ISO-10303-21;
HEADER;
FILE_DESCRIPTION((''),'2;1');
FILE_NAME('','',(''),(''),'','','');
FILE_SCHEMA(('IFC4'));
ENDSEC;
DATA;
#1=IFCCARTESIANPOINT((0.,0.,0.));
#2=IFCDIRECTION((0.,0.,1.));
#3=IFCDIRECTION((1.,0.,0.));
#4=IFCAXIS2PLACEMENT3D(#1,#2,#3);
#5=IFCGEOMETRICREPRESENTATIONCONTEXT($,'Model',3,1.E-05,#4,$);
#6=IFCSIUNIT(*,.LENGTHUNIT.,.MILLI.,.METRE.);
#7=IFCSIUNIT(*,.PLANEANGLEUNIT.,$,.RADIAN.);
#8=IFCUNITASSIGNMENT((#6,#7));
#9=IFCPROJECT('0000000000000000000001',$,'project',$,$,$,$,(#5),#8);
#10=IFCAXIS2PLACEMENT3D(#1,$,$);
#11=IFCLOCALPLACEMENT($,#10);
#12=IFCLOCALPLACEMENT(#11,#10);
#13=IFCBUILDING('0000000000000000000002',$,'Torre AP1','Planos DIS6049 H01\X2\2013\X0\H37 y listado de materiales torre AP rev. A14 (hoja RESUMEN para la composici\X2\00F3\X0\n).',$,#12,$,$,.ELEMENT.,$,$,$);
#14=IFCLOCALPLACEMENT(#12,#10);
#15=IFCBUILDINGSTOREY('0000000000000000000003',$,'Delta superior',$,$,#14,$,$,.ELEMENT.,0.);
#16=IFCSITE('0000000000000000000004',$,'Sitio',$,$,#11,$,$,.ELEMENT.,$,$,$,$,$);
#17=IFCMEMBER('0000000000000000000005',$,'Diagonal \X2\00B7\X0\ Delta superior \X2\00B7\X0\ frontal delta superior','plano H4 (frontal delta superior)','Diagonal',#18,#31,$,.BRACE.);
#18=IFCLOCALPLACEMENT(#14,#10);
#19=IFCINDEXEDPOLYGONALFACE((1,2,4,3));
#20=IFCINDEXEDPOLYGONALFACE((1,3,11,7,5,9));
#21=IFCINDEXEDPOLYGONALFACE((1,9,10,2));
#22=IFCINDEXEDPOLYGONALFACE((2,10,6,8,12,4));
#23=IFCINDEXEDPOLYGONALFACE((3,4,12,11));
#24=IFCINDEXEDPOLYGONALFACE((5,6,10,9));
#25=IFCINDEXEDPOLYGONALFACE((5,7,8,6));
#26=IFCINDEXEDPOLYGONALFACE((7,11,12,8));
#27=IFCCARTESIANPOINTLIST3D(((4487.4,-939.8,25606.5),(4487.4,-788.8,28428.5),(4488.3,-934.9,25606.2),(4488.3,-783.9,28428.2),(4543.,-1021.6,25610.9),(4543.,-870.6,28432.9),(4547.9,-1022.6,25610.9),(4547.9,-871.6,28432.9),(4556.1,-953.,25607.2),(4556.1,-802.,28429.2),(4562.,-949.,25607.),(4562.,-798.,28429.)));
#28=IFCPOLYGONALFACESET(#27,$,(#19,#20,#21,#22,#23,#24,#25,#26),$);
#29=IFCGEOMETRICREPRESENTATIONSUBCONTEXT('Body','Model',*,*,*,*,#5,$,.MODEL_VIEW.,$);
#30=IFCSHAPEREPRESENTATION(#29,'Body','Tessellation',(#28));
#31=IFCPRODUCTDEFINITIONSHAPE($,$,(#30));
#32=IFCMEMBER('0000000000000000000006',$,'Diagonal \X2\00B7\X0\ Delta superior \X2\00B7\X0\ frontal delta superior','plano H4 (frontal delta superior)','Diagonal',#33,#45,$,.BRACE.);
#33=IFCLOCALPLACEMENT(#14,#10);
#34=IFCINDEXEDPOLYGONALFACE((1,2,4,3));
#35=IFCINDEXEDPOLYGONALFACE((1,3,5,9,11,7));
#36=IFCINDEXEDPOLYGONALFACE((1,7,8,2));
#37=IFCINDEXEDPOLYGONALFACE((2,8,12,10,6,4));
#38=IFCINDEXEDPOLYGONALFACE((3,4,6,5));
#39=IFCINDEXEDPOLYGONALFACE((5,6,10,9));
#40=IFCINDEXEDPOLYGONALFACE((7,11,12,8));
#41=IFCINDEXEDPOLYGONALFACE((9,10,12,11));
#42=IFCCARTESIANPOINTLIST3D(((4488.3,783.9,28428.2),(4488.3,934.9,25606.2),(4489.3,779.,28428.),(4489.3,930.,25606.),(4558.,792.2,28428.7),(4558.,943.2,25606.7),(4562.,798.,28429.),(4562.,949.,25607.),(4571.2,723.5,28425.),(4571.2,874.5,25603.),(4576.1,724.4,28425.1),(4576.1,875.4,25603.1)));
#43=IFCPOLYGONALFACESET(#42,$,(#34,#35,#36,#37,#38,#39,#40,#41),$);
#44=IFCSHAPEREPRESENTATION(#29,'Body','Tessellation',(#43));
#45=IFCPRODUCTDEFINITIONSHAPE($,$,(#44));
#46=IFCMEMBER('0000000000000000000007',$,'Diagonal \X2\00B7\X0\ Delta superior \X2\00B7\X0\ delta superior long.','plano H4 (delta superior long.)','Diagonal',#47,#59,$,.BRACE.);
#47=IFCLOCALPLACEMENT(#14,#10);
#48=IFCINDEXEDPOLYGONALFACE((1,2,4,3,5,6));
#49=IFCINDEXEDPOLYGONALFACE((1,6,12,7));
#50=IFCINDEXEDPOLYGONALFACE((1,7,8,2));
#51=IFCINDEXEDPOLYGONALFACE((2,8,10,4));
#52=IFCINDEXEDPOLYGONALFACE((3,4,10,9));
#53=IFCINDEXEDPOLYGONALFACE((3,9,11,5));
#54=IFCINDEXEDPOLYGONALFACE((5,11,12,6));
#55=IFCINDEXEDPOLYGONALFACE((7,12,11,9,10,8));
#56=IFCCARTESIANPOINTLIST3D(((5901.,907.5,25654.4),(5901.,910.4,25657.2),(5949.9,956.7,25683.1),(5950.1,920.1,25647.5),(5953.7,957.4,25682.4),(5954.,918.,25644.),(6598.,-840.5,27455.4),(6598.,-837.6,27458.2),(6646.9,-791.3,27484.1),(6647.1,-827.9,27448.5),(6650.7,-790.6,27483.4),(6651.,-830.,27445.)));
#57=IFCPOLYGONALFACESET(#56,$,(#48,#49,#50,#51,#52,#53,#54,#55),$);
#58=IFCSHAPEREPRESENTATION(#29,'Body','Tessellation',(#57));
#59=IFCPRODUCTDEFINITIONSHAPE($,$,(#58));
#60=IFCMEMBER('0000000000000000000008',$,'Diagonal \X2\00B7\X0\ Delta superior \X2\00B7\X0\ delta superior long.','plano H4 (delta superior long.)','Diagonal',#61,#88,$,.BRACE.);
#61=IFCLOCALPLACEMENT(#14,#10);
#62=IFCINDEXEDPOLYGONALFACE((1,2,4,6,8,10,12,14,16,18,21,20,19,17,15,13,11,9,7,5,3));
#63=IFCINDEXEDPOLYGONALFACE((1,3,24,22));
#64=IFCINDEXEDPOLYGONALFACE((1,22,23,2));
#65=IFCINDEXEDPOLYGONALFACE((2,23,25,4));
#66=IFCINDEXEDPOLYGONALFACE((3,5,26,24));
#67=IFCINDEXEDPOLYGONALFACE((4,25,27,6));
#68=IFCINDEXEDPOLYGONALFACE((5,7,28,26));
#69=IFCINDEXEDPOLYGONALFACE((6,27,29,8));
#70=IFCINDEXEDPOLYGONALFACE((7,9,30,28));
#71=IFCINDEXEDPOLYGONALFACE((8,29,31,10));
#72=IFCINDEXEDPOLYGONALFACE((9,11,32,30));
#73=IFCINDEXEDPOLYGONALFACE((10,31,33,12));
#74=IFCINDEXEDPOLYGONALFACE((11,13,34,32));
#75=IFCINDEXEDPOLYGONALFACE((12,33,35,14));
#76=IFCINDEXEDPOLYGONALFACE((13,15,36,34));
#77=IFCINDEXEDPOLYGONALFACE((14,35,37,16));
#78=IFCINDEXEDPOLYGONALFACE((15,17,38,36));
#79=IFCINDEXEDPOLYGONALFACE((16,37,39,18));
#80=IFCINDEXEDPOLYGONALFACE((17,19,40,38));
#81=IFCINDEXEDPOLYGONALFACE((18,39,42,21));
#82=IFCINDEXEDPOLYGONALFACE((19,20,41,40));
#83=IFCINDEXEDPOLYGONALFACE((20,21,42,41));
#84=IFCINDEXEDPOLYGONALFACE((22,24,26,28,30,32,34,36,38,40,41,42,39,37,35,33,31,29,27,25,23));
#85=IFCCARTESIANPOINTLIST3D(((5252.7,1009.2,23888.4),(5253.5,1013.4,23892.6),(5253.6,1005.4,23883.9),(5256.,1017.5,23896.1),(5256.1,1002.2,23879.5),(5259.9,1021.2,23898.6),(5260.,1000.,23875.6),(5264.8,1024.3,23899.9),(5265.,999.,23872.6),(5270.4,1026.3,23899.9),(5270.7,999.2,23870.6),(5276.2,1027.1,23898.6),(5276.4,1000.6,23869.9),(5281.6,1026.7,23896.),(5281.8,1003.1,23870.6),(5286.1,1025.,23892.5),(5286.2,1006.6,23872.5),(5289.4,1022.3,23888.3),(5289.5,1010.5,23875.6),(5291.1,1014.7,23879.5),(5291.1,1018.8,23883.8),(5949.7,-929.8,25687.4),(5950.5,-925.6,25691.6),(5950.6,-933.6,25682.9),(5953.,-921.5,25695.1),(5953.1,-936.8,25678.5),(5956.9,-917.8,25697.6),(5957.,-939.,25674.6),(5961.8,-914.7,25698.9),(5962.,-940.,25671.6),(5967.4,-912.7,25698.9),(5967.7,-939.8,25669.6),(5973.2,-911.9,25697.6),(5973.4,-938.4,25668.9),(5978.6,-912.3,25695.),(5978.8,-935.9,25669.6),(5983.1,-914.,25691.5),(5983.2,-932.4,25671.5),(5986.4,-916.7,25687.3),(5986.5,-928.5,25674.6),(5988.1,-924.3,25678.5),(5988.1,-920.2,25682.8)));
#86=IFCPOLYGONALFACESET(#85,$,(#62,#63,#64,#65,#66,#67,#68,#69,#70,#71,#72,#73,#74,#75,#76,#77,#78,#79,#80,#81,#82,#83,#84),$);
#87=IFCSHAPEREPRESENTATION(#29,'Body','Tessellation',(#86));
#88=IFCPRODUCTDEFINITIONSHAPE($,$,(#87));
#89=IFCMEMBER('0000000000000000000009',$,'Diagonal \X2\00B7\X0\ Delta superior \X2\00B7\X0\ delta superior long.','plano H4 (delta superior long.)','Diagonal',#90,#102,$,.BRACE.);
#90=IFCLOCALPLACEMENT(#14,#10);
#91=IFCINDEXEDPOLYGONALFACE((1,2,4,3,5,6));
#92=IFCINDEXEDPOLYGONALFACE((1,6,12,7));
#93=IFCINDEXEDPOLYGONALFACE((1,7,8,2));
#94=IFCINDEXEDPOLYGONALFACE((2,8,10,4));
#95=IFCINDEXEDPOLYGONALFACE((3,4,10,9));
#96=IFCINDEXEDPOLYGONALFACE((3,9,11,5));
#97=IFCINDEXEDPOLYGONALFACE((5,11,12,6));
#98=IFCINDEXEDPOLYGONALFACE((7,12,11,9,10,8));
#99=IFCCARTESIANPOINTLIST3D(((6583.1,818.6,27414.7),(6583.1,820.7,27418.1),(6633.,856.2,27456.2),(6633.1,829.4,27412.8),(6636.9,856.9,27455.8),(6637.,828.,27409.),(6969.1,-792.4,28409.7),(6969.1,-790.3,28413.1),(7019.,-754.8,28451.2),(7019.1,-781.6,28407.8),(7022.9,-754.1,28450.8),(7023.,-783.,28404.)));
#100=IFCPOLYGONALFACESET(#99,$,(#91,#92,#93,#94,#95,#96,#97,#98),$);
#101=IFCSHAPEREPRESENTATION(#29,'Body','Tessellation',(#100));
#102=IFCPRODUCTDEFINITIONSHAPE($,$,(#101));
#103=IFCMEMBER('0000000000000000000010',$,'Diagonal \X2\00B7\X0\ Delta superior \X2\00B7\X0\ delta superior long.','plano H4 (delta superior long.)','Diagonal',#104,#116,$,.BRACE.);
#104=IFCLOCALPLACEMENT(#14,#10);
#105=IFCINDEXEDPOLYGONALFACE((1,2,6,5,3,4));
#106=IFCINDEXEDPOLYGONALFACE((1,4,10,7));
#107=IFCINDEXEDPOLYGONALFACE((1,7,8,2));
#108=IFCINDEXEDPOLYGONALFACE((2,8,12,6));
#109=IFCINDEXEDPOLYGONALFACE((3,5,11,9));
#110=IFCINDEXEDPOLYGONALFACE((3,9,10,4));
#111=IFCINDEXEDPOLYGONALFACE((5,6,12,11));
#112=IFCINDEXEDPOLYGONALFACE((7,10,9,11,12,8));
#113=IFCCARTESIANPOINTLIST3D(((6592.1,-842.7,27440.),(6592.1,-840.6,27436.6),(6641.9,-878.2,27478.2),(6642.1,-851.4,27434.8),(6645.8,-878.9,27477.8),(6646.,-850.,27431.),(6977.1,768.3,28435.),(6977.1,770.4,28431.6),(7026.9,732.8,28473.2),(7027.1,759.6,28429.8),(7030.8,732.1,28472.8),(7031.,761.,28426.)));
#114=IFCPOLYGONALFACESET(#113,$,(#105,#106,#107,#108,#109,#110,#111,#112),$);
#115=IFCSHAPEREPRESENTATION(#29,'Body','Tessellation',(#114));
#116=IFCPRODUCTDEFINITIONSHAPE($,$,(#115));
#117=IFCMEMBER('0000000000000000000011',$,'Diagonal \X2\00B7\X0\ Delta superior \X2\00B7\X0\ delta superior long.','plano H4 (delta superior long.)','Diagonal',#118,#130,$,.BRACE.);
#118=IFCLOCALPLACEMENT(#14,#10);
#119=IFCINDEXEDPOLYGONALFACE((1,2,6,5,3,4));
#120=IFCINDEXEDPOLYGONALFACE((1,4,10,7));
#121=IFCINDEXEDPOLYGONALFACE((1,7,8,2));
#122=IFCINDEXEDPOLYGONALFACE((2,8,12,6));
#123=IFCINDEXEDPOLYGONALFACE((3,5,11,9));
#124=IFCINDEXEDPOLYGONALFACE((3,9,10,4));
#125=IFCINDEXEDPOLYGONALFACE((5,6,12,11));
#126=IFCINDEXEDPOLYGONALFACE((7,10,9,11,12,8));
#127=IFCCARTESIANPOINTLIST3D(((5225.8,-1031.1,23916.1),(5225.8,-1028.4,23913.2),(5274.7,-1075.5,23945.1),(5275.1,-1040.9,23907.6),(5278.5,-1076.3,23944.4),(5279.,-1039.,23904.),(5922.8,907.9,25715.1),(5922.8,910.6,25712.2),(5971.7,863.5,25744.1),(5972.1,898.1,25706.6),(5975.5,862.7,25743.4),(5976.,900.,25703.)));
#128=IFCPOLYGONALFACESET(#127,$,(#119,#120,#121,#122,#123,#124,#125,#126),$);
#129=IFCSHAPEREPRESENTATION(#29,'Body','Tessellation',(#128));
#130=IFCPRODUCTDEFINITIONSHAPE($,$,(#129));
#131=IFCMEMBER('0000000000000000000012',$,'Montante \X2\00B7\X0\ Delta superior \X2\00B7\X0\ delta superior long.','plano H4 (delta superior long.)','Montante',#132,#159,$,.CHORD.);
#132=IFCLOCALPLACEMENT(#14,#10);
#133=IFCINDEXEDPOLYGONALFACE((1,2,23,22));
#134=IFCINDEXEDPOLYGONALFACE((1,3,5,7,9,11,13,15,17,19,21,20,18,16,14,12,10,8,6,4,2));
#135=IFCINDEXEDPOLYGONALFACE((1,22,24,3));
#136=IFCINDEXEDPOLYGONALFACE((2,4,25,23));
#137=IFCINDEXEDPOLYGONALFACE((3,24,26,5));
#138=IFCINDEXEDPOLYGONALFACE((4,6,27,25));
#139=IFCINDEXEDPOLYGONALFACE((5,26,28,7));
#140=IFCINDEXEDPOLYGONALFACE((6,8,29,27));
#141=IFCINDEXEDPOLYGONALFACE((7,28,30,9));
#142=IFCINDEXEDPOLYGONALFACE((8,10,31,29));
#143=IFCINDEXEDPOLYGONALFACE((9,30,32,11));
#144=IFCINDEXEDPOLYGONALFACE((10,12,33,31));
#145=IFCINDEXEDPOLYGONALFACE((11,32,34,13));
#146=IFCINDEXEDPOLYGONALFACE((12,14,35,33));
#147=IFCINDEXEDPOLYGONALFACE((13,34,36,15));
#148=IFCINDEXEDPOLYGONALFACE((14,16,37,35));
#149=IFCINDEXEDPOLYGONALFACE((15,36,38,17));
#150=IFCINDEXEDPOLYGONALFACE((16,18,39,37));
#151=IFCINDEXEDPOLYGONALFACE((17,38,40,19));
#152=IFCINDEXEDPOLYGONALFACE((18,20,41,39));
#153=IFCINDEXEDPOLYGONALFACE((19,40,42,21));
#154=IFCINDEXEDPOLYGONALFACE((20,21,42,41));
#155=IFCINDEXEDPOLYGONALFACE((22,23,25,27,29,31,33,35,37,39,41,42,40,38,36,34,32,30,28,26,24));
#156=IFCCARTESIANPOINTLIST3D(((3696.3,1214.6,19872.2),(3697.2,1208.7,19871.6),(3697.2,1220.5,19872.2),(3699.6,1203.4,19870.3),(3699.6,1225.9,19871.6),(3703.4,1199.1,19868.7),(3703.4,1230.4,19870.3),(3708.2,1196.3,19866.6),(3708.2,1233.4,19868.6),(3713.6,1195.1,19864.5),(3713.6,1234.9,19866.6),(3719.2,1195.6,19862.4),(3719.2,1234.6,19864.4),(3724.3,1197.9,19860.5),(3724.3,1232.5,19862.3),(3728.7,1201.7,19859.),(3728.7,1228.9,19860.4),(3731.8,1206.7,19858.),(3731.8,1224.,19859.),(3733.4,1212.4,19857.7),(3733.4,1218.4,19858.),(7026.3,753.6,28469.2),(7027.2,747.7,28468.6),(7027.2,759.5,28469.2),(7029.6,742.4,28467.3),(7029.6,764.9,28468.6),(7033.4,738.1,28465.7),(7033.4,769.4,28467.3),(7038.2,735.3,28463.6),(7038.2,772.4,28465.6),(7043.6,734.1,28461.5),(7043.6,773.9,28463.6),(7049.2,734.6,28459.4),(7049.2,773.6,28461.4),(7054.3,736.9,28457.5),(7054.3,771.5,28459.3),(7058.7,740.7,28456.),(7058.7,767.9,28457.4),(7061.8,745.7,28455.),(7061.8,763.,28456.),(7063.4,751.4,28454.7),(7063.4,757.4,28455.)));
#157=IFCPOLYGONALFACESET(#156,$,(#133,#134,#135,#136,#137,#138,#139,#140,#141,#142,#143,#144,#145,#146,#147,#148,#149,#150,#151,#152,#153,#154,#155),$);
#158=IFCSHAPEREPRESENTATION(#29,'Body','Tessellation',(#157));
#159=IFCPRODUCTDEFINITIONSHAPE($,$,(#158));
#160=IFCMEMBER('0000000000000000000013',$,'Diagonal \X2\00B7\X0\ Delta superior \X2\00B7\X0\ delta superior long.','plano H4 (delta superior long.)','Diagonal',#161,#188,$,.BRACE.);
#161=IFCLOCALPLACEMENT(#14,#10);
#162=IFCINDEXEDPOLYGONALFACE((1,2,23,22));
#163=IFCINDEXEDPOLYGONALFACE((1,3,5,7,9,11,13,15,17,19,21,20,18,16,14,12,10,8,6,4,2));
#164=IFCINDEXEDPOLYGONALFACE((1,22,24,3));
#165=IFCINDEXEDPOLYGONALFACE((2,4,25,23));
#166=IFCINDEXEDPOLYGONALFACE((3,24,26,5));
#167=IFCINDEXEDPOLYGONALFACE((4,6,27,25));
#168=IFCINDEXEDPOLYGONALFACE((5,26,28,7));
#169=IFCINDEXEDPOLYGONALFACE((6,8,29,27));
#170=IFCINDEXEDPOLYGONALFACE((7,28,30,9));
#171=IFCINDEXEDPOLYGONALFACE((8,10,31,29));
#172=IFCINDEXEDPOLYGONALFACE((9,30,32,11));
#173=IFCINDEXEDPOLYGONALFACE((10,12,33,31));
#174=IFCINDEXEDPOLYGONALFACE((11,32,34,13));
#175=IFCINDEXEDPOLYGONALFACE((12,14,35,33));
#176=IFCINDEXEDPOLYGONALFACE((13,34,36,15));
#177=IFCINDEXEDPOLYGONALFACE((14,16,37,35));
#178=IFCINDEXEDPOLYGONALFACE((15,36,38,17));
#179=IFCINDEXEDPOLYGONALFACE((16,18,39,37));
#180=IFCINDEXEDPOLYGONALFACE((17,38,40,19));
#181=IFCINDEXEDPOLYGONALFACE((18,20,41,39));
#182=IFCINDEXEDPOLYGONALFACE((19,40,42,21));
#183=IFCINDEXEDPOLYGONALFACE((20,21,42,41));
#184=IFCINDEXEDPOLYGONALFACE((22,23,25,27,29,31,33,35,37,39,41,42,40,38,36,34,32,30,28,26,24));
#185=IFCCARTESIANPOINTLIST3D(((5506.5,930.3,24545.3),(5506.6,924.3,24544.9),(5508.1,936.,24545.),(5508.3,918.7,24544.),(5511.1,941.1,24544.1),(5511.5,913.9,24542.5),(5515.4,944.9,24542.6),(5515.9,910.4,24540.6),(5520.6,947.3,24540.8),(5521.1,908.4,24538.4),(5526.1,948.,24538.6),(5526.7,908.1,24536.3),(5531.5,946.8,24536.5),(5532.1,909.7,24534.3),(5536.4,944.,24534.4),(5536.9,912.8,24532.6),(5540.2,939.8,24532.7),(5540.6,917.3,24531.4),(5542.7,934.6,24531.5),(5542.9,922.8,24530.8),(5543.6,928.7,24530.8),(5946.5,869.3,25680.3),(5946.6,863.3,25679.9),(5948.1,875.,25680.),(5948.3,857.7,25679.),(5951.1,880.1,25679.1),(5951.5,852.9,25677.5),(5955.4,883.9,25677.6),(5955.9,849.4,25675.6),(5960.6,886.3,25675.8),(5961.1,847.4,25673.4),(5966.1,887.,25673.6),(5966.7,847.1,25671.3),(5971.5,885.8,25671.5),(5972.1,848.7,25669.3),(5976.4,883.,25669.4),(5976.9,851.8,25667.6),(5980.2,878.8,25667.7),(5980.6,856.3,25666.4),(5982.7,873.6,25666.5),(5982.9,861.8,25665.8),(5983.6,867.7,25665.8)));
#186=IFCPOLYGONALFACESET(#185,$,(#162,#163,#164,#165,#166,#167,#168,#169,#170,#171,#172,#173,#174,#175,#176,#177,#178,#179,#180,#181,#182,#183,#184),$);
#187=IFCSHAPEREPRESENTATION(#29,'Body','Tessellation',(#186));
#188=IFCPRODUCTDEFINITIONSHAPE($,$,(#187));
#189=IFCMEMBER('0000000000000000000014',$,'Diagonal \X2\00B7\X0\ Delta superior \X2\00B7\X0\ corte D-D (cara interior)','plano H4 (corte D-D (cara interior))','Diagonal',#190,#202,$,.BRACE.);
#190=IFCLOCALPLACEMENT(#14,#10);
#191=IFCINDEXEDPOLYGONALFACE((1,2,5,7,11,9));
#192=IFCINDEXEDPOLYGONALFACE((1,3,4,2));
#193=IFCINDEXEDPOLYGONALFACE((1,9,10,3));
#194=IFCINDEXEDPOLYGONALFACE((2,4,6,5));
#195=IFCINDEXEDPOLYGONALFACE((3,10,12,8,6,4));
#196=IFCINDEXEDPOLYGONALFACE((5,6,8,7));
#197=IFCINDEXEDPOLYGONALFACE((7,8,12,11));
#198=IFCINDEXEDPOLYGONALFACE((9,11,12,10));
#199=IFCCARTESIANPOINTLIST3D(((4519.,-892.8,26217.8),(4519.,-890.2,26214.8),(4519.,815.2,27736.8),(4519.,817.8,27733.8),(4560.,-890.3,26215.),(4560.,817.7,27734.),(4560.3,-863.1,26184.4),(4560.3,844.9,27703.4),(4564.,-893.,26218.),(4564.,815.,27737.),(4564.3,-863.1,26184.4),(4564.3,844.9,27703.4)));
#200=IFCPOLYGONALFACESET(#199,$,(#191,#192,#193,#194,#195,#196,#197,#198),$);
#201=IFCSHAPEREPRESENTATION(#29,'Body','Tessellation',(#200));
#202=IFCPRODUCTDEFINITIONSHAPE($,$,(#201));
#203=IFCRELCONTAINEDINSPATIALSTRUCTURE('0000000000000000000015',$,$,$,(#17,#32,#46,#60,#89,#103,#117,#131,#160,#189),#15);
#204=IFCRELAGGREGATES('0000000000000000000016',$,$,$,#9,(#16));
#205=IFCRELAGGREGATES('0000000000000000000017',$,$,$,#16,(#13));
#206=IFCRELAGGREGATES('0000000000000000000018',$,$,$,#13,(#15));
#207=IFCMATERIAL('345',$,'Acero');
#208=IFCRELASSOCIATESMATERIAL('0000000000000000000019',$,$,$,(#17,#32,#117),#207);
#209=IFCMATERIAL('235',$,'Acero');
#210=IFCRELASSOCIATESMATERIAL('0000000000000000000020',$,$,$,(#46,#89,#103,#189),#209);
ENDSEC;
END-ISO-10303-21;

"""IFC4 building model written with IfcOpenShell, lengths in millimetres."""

from ifc_helpers import new_model, si_unit, frame, frame_2d, origin, origin_with_axes, place, context, subcontext, project, spatial, circle, l_section, extrude, material, element, save


model = new_model("IFC4")

# Units and contexts
model_context = context("Model", 3, precision=1e-05, world=origin_with_axes())
body_context = subcontext(model_context, "Body", "Model", "MODEL_VIEW")
ifc_project = project(units=[si_unit("LENGTHUNIT", "METRE", prefix="MILLI"), si_unit("PLANEANGLEUNIT", "RADIAN")], contexts=[model_context])

# Site, building, storey
site_placement = place(None, origin())
site = spatial("IfcSite", under=ifc_project, at=site_placement, Name="Sitio", CompositionType="ELEMENT")
building_placement = place(site_placement, origin())
building = spatial("IfcBuilding", under=site, at=building_placement, Name="Torre AP1", Description="Planos DIS6049 H01–H37 y listado de materiales torre AP rev. A14 (hoja RESUMEN para la composición).", CompositionType="ELEMENT")
storey_placement = place(building_placement, origin())
storey = spatial("IfcBuildingStorey", under=building, at=storey_placement, Name="Delta superior", CompositionType="ELEMENT", Elevation=0.0)

# Members
ifc_material_1 = material(Name="235", Category="Acero")
ifc_material_2 = material(Name="345", Category="Acero")
for number, where, z_axis, x_axis, name in (
    (1, (4562.0, -949.0, 25607.0), (0.0, 0.053432, 0.998572), (-0.982208, 0.187529, -0.010034), "Diagonal · Delta superior · frontal delta superior"),
    (2, (4562.0, 949.0, 25607.0), (0.0, -0.053432, 0.998572), (-0.982208, -0.187529, -0.010034), "Diagonal · Delta superior · frontal delta superior"),
):
    element("IfcMember", number, at=place(storey_placement, frame(where, z_axis=z_axis, x_axis=x_axis)), inside=storey, material=ifc_material_2, Name=name, Description="plano H4 (frontal delta superior)", ObjectType="Diagonal", PredefinedType="BRACE", context=body_context, shape_type="SweptSolid", body=[
        extrude(l_section(Depth=75.0, Width=75.0, Thickness=5.0, at=frame_2d((37.5, 37.5))), None, (0.0, 0.0, 1.0), 2826.0),
    ])
member_1_placement = place(storey_placement, frame((6651.0, -830.0, 27445.0), z_axis=(-0.267584, 0.671072, -0.691419), x_axis=(-0.963521, -0.190088, 0.188396)))
element("IfcMember", 3, at=member_1_placement, inside=storey, material=ifc_material_1, Name="Diagonal · Delta superior · delta superior long.", Description="plano H4 (delta superior long.)", ObjectType="Diagonal", PredefinedType="BRACE", context=body_context, shape_type="SweptSolid", body=[
    extrude(l_section(Depth=55.0, Width=55.0, Thickness=4.0, at=frame_2d((27.5, 27.5))), None, (0.0, 0.0, 1.0), 2604.8),
])
member_2_placement = place(storey_placement, frame((5969.0, -926.0, 25684.0), z_axis=(-0.254816, 0.708877, -0.657695), x_axis=(-0.966975, -0.190493, 0.169325)))
element("IfcMember", 4, at=member_2_placement, inside=storey, Name="Diagonal · Delta superior · delta superior long.", Description="plano H4 (delta superior long.)", ObjectType="Diagonal", PredefinedType="BRACE", context=body_context, shape_type="SweptSolid", body=[
    extrude(circle(Radius=20.0), None, (0.0, 0.0, 1.0), 2735.3),
])
member_3_placement = place(storey_placement, frame((7023.0, -783.0, 28404.0), z_axis=(-0.199747, 0.833659, -0.514892), x_axis=(-0.979846, -0.170873, 0.103461)))
element("IfcMember", 5, at=member_3_placement, inside=storey, material=ifc_material_1, Name="Diagonal · Delta superior · delta superior long.", Description="plano H4 (delta superior long.)", ObjectType="Diagonal", PredefinedType="BRACE", context=body_context, shape_type="SweptSolid", body=[
    extrude(l_section(Depth=55.0, Width=55.0, Thickness=4.0, at=frame_2d((27.5, 27.5))), None, (0.0, 0.0, 1.0), 1932.4),
])
member_4_placement = place(storey_placement, frame((6646.0, -850.0, 27431.0), z_axis=(0.19925, 0.833745, 0.514945), x_axis=(-0.979943, 0.171353, 0.101736)))
element("IfcMember", 6, at=member_4_placement, inside=storey, material=ifc_material_1, Name="Diagonal · Delta superior · delta superior long.", Description="plano H4 (delta superior long.)", ObjectType="Diagonal", PredefinedType="BRACE", context=body_context, shape_type="SweptSolid", body=[
    extrude(l_section(Depth=55.0, Width=55.0, Thickness=4.0, at=frame_2d((27.5, 27.5))), None, (0.0, 0.0, 1.0), 1932.2),
])
member_5_placement = place(storey_placement, frame((5279.0, -1039.0, 23904.0), z_axis=(0.254816, 0.708877, 0.657695), x_axis=(-0.966953, 0.192686, 0.166953)))
element("IfcMember", 7, at=member_5_placement, inside=storey, material=ifc_material_2, Name="Diagonal · Delta superior · delta superior long.", Description="plano H4 (delta superior long.)", ObjectType="Diagonal", PredefinedType="BRACE", context=body_context, shape_type="SweptSolid", body=[
    extrude(l_section(Depth=55.0, Width=55.0, Thickness=4.0, at=frame_2d((27.5, 27.5))), None, (0.0, 0.0, 1.0), 2735.3),
])
for number, where, z_axis, x_axis, name in (
    (8, (3715.0, 1215.0, 19865.0), (0.360744, -0.049941, 0.931327), (-0.932665, -0.019317, 0.360227), "Montante · Delta superior · delta superior long."),
):
    element("IfcMember", number, at=place(storey_placement, frame(where, z_axis=z_axis, x_axis=x_axis)), inside=storey, Name=name, Description="plano H4 (delta superior long.)", ObjectType="Montante", PredefinedType="CHORD", context=body_context, shape_type="SweptSolid", body=[
        extrude(circle(Radius=20.0), None, (0.0, 0.0, 1.0), 9230.9),
    ])
member_6_placement = place(storey_placement, frame((5525.0, 928.0, 24538.0), z_axis=(0.361002, -0.050048, 0.931221), x_axis=(-0.919866, -0.183339, 0.346747)))
element("IfcMember", 9, at=member_6_placement, inside=storey, Name="Diagonal · Delta superior · delta superior long.", Description="plano H4 (delta superior long.)", ObjectType="Diagonal", PredefinedType="BRACE", context=body_context, shape_type="SweptSolid", body=[
    extrude(circle(Radius=20.0), None, (0.0, 0.0, 1.0), 1218.8),
])
member_7_placement = place(storey_placement, frame((4564.0, 815.0, 27737.0), z_axis=(0.0, -0.74724, -0.664554), x_axis=(-0.999984, 0.003774, -0.004243)))
element("IfcMember", 10, at=member_7_placement, inside=storey, material=ifc_material_1, Name="Diagonal · Delta superior · corte D-D (cara interior)", Description="plano H4 (corte D-D (cara interior))", ObjectType="Diagonal", PredefinedType="BRACE", context=body_context, shape_type="SweptSolid", body=[
    extrude(l_section(Depth=45.0, Width=45.0, Thickness=4.0, at=frame_2d((22.5, 22.5))), None, (0.0, 0.0, 1.0), 2285.7),
])

save(model, "model.ifc")
